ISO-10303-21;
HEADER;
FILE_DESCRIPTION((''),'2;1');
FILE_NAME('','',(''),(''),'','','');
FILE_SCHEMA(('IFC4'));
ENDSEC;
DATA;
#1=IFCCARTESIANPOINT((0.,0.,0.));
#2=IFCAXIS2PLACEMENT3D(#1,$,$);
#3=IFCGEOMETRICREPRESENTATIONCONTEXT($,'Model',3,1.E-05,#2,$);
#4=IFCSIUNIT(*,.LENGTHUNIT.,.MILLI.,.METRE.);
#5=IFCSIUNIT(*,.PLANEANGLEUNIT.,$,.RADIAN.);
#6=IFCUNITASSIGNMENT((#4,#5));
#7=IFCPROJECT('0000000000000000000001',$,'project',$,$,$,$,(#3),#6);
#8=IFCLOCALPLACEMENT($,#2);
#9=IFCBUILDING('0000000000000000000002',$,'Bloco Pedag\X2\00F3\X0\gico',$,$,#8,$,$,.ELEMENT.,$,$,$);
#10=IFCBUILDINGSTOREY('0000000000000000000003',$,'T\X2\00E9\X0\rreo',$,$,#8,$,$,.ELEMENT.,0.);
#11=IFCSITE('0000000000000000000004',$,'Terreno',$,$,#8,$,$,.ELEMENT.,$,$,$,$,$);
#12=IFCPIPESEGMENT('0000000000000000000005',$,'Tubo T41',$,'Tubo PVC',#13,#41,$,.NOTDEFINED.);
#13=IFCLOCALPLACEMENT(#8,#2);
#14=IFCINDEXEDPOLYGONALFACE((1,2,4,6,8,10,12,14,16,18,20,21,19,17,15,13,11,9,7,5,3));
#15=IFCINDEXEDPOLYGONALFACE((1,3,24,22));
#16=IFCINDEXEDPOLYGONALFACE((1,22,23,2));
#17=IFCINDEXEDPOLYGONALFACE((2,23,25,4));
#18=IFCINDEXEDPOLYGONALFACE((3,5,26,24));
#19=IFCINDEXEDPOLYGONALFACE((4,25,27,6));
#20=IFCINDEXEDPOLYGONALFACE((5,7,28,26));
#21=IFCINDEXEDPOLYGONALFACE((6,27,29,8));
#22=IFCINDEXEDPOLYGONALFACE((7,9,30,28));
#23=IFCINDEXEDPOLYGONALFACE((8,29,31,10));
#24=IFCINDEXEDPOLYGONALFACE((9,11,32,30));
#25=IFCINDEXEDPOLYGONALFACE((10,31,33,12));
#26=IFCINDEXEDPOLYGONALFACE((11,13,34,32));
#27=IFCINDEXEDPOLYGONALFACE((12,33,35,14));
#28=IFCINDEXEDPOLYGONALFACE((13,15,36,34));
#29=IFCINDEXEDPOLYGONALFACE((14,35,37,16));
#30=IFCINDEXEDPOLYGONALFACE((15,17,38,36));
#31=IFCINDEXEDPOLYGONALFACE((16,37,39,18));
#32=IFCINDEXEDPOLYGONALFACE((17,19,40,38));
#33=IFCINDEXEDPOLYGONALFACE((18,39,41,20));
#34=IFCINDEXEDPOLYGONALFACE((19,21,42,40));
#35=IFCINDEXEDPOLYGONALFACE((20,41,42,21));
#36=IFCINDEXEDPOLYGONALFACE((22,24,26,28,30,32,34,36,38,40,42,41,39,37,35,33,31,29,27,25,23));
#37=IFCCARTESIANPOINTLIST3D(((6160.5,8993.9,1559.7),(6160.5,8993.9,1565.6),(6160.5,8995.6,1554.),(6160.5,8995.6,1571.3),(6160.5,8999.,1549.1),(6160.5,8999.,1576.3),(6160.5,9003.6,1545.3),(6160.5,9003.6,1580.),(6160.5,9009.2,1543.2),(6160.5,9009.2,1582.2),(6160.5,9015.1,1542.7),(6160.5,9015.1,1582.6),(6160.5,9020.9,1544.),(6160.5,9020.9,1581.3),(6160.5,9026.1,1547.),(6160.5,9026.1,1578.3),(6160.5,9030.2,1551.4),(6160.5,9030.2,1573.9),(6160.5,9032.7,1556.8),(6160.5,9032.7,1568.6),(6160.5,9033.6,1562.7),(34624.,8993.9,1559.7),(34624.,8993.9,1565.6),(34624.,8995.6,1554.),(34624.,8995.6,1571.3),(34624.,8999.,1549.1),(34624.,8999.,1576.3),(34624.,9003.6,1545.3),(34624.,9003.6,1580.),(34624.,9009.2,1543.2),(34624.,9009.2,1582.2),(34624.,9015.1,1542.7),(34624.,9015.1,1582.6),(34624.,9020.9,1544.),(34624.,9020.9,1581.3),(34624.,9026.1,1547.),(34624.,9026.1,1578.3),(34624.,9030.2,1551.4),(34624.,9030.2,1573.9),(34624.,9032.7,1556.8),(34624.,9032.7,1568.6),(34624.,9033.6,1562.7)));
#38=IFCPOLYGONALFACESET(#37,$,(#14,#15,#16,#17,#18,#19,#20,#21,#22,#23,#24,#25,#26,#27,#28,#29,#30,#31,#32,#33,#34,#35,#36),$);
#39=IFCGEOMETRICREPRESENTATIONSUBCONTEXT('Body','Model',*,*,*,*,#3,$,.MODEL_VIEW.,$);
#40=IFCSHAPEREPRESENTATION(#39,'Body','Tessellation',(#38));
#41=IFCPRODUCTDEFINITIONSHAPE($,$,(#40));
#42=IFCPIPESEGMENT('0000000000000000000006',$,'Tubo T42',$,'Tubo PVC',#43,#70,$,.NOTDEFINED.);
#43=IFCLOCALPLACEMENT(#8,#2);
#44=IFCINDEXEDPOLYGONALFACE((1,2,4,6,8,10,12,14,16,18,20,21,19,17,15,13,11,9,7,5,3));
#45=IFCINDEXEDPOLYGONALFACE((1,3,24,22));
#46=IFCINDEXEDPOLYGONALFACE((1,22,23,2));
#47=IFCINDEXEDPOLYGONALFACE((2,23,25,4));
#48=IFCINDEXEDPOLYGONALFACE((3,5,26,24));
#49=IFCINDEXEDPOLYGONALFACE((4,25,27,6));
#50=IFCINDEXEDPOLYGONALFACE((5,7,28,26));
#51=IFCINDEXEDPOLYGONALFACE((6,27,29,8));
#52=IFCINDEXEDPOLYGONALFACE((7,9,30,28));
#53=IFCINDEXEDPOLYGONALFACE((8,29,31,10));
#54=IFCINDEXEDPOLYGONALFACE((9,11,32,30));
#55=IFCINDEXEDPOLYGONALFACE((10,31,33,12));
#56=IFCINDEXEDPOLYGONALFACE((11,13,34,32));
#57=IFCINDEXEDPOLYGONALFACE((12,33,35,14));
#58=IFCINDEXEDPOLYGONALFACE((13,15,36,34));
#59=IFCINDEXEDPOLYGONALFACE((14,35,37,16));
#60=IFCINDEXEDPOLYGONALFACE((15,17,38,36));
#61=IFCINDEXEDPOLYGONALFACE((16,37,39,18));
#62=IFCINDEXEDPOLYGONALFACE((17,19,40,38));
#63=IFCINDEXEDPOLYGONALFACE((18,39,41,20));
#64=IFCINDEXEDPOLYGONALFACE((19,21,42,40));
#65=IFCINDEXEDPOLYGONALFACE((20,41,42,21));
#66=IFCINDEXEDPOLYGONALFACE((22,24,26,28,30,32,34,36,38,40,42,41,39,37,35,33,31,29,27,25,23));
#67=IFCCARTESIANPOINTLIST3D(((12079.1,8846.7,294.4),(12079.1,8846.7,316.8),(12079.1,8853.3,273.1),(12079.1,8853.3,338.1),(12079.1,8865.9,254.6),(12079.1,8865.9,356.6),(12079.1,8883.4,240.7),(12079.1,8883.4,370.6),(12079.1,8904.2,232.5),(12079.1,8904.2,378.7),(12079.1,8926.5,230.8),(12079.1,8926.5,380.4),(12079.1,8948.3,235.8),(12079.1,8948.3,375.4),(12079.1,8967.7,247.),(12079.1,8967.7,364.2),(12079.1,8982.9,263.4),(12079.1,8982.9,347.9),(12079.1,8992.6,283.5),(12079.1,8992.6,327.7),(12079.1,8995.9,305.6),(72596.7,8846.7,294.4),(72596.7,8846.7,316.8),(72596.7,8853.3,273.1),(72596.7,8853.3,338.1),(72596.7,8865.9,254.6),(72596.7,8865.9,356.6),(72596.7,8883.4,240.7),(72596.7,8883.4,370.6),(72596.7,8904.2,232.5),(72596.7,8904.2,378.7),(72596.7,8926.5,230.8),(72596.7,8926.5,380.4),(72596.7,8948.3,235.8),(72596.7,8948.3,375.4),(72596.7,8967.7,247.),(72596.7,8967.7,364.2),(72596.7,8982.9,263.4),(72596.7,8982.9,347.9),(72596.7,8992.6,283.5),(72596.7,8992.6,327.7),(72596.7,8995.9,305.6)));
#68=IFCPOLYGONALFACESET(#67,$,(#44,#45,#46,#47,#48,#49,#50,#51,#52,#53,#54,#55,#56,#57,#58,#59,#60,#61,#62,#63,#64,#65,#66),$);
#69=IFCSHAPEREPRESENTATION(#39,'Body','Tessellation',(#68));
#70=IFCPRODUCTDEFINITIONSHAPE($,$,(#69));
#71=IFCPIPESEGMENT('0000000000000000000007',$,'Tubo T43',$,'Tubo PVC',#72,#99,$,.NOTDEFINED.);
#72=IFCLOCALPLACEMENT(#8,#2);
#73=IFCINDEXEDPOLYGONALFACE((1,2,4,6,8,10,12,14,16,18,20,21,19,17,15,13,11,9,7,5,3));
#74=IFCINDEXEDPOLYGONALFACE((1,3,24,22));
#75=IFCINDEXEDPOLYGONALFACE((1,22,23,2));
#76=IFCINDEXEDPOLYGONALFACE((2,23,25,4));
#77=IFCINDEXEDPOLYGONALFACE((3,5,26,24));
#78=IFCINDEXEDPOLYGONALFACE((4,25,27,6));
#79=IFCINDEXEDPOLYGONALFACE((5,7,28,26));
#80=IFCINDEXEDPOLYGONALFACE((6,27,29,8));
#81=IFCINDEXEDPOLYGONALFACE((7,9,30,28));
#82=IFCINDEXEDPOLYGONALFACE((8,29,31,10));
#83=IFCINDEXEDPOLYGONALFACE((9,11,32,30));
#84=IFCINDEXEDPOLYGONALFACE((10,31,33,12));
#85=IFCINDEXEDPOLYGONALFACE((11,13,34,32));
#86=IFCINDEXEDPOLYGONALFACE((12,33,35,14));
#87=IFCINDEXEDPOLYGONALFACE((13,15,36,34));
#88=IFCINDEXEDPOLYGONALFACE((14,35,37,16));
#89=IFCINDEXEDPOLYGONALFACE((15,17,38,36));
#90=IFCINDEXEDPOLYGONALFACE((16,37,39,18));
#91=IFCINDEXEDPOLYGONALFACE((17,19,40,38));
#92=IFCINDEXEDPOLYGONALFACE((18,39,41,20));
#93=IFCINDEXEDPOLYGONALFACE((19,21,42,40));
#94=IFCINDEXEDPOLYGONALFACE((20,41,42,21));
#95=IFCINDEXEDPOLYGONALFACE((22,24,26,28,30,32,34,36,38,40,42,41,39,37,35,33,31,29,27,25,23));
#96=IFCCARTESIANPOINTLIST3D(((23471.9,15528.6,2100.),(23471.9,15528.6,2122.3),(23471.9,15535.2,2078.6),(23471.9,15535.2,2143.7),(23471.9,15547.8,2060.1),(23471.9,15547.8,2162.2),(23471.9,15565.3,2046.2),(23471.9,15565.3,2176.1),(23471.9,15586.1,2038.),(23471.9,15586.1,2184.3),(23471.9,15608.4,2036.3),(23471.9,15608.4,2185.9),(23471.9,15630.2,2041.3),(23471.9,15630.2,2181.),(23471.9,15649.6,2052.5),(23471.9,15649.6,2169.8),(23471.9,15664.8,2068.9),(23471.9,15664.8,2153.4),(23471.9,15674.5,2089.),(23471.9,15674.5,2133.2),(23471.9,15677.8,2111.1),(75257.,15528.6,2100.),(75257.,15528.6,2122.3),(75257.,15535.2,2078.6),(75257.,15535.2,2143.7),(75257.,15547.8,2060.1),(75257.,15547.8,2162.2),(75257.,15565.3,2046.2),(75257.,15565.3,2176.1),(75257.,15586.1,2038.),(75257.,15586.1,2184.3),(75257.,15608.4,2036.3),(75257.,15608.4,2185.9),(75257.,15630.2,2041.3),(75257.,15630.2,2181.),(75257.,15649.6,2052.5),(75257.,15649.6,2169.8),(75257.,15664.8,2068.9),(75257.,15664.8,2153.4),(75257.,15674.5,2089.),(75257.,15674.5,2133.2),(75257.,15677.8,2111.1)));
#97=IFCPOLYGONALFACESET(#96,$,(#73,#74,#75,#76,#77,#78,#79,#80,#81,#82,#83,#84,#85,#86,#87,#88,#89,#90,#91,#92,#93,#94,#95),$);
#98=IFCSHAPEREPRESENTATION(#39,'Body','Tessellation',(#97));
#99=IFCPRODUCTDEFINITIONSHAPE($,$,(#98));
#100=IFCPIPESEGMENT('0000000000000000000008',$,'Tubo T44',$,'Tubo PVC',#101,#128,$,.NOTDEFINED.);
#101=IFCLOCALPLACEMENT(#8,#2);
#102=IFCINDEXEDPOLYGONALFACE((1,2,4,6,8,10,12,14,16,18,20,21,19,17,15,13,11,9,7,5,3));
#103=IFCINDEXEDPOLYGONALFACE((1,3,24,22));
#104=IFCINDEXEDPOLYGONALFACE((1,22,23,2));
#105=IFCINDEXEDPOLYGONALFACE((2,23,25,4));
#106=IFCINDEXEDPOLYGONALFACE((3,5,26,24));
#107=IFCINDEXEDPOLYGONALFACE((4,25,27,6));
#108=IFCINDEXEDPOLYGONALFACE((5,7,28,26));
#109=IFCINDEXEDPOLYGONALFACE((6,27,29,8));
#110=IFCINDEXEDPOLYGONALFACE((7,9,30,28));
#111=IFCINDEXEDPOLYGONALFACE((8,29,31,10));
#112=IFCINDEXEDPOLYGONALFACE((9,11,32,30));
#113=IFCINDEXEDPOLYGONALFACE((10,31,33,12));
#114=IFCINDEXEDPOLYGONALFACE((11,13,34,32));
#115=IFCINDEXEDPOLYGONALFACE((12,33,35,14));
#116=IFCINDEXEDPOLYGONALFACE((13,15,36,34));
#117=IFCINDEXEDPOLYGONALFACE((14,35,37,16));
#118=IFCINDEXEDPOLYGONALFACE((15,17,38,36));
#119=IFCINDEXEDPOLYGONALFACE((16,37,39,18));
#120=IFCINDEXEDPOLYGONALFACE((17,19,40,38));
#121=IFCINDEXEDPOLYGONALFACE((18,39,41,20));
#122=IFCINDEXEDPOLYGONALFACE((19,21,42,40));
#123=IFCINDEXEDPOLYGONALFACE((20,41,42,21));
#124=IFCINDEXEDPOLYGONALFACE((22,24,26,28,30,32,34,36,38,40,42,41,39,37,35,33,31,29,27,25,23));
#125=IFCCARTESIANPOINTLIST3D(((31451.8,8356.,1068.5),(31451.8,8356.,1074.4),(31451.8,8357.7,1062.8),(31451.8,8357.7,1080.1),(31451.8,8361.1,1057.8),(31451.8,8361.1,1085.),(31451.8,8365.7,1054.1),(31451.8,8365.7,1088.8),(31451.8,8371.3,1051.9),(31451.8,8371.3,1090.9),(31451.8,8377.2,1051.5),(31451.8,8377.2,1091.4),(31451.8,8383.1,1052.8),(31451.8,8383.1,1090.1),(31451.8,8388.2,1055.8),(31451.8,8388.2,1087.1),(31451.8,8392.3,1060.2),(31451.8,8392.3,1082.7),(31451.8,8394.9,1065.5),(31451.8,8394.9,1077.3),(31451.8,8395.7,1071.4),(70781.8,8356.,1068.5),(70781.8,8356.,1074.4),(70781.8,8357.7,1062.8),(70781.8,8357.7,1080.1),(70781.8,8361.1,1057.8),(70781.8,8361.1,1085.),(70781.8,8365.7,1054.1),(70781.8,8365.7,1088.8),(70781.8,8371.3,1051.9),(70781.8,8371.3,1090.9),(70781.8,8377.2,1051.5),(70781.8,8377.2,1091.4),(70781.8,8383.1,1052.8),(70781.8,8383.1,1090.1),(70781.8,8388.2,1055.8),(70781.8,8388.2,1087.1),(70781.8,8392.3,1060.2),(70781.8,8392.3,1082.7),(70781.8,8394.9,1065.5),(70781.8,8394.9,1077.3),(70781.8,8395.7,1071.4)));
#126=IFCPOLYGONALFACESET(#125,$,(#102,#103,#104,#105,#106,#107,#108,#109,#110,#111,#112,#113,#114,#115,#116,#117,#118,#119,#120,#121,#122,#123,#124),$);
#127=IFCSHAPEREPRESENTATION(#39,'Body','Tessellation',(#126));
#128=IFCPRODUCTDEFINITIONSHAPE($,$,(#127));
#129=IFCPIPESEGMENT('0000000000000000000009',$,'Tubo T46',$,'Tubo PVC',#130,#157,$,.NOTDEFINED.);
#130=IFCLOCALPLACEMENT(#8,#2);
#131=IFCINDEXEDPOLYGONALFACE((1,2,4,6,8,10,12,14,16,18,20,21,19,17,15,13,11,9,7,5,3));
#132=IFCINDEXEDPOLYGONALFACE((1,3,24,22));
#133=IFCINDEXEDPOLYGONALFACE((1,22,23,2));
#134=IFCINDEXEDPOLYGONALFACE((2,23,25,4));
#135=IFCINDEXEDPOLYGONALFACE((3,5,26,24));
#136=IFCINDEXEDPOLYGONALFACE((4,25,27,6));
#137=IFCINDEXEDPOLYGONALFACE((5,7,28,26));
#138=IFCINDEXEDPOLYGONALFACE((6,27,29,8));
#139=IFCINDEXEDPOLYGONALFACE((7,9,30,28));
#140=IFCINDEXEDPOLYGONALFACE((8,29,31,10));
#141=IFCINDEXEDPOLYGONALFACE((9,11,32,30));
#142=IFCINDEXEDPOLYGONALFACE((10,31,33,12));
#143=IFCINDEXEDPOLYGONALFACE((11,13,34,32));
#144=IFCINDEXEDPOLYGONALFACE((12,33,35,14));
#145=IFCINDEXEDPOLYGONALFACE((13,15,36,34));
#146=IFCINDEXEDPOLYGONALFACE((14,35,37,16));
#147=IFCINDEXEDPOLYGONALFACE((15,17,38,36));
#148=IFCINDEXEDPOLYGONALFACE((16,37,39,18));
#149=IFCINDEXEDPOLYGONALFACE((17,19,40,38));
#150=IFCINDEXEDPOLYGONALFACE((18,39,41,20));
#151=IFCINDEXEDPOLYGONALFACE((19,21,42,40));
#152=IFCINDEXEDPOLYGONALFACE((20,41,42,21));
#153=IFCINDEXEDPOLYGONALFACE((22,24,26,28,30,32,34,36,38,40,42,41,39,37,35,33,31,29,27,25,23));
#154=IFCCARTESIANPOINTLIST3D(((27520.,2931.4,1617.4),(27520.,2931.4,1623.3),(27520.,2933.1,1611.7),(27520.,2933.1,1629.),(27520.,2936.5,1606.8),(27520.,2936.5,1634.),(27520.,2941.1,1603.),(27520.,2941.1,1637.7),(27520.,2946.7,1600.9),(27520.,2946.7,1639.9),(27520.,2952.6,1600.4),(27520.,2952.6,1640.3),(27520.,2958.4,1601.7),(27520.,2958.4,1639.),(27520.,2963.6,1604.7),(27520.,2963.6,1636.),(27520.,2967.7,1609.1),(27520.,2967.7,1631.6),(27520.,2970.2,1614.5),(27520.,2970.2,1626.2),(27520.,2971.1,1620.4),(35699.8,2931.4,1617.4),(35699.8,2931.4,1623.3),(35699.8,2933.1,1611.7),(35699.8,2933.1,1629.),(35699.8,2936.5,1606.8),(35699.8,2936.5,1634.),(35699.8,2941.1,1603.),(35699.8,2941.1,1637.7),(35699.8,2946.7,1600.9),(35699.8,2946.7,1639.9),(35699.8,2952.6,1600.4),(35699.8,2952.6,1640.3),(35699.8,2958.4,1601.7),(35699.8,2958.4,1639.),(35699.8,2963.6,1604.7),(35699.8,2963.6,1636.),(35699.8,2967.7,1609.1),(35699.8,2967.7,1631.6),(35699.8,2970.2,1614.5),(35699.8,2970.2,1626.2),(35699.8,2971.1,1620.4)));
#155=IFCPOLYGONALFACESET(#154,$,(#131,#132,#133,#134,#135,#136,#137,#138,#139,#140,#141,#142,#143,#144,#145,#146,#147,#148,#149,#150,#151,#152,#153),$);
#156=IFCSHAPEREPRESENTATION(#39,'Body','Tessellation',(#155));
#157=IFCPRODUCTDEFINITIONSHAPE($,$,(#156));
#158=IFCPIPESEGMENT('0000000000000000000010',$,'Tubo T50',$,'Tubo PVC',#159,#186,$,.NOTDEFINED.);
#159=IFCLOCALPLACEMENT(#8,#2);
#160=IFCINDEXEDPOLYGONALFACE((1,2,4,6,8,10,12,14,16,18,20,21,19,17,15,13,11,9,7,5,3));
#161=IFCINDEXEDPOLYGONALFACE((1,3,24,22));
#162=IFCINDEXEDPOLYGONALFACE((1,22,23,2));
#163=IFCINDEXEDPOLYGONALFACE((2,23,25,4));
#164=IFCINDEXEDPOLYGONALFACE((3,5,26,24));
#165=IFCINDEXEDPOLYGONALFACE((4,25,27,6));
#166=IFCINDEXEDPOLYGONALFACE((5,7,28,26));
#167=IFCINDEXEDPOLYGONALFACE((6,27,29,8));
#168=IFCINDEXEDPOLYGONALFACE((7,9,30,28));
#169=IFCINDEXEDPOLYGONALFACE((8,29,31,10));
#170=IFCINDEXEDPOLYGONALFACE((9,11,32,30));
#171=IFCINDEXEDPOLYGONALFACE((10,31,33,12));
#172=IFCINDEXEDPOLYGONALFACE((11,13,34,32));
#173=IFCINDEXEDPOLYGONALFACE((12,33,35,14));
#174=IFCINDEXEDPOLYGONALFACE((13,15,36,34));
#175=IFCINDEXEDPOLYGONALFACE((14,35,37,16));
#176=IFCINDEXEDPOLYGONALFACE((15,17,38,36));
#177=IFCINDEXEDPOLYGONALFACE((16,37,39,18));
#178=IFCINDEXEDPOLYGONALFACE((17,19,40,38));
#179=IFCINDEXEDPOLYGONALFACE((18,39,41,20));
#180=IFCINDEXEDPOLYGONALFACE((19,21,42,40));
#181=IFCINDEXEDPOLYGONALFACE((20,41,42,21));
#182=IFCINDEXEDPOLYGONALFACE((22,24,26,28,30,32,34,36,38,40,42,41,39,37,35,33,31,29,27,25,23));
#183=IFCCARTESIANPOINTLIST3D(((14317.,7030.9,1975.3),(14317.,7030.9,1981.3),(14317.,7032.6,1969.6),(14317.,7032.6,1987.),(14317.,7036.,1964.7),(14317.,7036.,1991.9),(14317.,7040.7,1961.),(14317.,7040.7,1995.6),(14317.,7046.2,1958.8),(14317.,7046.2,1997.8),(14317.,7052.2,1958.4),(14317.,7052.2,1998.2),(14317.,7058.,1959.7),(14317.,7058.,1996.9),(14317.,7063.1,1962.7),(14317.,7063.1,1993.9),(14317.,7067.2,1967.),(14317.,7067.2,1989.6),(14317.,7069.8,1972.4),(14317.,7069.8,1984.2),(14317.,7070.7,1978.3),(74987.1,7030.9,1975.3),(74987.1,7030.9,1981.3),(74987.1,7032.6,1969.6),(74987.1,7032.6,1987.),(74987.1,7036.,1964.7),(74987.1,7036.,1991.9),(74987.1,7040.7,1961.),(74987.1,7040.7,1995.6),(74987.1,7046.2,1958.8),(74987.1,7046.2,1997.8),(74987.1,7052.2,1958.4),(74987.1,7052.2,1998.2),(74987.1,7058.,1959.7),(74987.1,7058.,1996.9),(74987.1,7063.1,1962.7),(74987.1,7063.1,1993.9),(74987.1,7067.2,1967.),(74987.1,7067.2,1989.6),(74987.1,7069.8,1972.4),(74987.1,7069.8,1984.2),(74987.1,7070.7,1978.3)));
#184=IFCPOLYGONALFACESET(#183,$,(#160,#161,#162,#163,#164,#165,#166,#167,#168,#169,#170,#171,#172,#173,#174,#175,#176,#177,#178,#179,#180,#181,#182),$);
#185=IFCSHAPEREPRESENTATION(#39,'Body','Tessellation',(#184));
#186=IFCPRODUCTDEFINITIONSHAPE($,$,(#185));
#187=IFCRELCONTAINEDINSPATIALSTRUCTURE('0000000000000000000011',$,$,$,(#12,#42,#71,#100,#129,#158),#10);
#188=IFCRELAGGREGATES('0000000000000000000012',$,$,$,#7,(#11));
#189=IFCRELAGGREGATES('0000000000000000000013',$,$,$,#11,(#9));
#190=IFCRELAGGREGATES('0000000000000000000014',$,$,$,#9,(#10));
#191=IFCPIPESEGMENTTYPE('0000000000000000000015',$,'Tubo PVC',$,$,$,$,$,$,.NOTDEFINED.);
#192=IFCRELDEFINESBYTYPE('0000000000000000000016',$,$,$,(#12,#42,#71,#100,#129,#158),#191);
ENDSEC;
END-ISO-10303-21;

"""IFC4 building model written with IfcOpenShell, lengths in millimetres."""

from ifc_helpers import new_model, si_unit, frame, origin, origin_2d, place, context, subcontext, project, spatial, circle, extrude, type_object, element, save


model = new_model("IFC4")

# Units and contexts
model_context = context("Model", 3, precision=1e-05, world=origin())
body_context = subcontext(model_context, "Body", "Model", "MODEL_VIEW")
ifc_project = project(units=[si_unit("LENGTHUNIT", "METRE", prefix="MILLI"), si_unit("PLANEANGLEUNIT", "RADIAN")], contexts=[model_context])

# Site, building, storey
placement = place(None, origin())
site = spatial("IfcSite", under=ifc_project, at=placement, Name="Terreno", CompositionType="ELEMENT")
building = spatial("IfcBuilding", under=site, at=placement, Name="Bloco Pedagógico", CompositionType="ELEMENT")
storey = spatial("IfcBuildingStorey", under=building, at=placement, Name="Térreo", CompositionType="ELEMENT", Elevation=0.0)

# Pipe segments
pipe_segment_type = type_object("IfcPipeSegmentType", Name="Tubo PVC", PredefinedType="NOTDEFINED")
pipe_segment_1_placement = place(None, frame((6160.5, 9013.6, 1562.7), z_axis=(1.0, 0.0, 0.0), x_axis=(0.0, 1.0, 0.0)))
element("IfcPipeSegment", 1, at=pipe_segment_1_placement, inside=storey, type_object=pipe_segment_type, Name="Tubo T41", ObjectType="Tubo PVC", PredefinedType="NOTDEFINED", context=body_context, shape_type="SweptSolid", body=[
    extrude(circle(Radius=20.0, at=origin_2d()), None, (0.0, 0.0, 1.0), 28463.5),
])
pipe_segment_2_placement = place(None, frame((12079.1, 8920.9, 305.6), z_axis=(1.0, 0.0, 0.0), x_axis=(0.0, 1.0, 0.0)))
element("IfcPipeSegment", 2, at=pipe_segment_2_placement, inside=storey, type_object=pipe_segment_type, Name="Tubo T42", ObjectType="Tubo PVC", PredefinedType="NOTDEFINED", context=body_context, shape_type="SweptSolid", body=[
    extrude(circle(Radius=75.0, at=origin_2d()), None, (0.0, 0.0, 1.0), 60517.6),
])
pipe_segment_3_placement = place(None, frame((23471.9, 15602.8, 2111.1), z_axis=(1.0, 0.0, 0.0), x_axis=(0.0, 1.0, 0.0)))
element("IfcPipeSegment", 3, at=pipe_segment_3_placement, inside=storey, type_object=pipe_segment_type, Name="Tubo T43", ObjectType="Tubo PVC", PredefinedType="NOTDEFINED", context=body_context, shape_type="SweptSolid", body=[
    extrude(circle(Radius=75.0, at=origin_2d()), None, (0.0, 0.0, 1.0), 51785.1),
])
pipe_segment_4_placement = place(None, frame((31451.8, 8375.7, 1071.4), z_axis=(1.0, 0.0, 0.0), x_axis=(0.0, 1.0, 0.0)))
element("IfcPipeSegment", 4, at=pipe_segment_4_placement, inside=storey, type_object=pipe_segment_type, Name="Tubo T44", ObjectType="Tubo PVC", PredefinedType="NOTDEFINED", context=body_context, shape_type="SweptSolid", body=[
    extrude(circle(Radius=20.0, at=origin_2d()), None, (0.0, 0.0, 1.0), 39330.0),
])
pipe_segment_5_placement = place(None, frame((27520.0, 2951.1, 1620.4), z_axis=(1.0, 0.0, 0.0), x_axis=(0.0, 1.0, 0.0)))
element("IfcPipeSegment", 5, at=pipe_segment_5_placement, inside=storey, type_object=pipe_segment_type, Name="Tubo T46", ObjectType="Tubo PVC", PredefinedType="NOTDEFINED", context=body_context, shape_type="SweptSolid", body=[
    extrude(circle(Radius=20.0, at=origin_2d()), None, (0.0, 0.0, 1.0), 8179.8),
])
pipe_segment_6_placement = place(None, frame((14317.0, 7050.7, 1978.3), z_axis=(1.0, 0.0, 0.0), x_axis=(0.0, 1.0, 0.0)))
element("IfcPipeSegment", 6, at=pipe_segment_6_placement, inside=storey, type_object=pipe_segment_type, Name="Tubo T50", ObjectType="Tubo PVC", PredefinedType="NOTDEFINED", context=body_context, shape_type="SweptSolid", body=[
    extrude(circle(Radius=20.0, at=origin_2d()), None, (0.0, 0.0, 1.0), 60670.1),
])

save(model, "model.ifc")
